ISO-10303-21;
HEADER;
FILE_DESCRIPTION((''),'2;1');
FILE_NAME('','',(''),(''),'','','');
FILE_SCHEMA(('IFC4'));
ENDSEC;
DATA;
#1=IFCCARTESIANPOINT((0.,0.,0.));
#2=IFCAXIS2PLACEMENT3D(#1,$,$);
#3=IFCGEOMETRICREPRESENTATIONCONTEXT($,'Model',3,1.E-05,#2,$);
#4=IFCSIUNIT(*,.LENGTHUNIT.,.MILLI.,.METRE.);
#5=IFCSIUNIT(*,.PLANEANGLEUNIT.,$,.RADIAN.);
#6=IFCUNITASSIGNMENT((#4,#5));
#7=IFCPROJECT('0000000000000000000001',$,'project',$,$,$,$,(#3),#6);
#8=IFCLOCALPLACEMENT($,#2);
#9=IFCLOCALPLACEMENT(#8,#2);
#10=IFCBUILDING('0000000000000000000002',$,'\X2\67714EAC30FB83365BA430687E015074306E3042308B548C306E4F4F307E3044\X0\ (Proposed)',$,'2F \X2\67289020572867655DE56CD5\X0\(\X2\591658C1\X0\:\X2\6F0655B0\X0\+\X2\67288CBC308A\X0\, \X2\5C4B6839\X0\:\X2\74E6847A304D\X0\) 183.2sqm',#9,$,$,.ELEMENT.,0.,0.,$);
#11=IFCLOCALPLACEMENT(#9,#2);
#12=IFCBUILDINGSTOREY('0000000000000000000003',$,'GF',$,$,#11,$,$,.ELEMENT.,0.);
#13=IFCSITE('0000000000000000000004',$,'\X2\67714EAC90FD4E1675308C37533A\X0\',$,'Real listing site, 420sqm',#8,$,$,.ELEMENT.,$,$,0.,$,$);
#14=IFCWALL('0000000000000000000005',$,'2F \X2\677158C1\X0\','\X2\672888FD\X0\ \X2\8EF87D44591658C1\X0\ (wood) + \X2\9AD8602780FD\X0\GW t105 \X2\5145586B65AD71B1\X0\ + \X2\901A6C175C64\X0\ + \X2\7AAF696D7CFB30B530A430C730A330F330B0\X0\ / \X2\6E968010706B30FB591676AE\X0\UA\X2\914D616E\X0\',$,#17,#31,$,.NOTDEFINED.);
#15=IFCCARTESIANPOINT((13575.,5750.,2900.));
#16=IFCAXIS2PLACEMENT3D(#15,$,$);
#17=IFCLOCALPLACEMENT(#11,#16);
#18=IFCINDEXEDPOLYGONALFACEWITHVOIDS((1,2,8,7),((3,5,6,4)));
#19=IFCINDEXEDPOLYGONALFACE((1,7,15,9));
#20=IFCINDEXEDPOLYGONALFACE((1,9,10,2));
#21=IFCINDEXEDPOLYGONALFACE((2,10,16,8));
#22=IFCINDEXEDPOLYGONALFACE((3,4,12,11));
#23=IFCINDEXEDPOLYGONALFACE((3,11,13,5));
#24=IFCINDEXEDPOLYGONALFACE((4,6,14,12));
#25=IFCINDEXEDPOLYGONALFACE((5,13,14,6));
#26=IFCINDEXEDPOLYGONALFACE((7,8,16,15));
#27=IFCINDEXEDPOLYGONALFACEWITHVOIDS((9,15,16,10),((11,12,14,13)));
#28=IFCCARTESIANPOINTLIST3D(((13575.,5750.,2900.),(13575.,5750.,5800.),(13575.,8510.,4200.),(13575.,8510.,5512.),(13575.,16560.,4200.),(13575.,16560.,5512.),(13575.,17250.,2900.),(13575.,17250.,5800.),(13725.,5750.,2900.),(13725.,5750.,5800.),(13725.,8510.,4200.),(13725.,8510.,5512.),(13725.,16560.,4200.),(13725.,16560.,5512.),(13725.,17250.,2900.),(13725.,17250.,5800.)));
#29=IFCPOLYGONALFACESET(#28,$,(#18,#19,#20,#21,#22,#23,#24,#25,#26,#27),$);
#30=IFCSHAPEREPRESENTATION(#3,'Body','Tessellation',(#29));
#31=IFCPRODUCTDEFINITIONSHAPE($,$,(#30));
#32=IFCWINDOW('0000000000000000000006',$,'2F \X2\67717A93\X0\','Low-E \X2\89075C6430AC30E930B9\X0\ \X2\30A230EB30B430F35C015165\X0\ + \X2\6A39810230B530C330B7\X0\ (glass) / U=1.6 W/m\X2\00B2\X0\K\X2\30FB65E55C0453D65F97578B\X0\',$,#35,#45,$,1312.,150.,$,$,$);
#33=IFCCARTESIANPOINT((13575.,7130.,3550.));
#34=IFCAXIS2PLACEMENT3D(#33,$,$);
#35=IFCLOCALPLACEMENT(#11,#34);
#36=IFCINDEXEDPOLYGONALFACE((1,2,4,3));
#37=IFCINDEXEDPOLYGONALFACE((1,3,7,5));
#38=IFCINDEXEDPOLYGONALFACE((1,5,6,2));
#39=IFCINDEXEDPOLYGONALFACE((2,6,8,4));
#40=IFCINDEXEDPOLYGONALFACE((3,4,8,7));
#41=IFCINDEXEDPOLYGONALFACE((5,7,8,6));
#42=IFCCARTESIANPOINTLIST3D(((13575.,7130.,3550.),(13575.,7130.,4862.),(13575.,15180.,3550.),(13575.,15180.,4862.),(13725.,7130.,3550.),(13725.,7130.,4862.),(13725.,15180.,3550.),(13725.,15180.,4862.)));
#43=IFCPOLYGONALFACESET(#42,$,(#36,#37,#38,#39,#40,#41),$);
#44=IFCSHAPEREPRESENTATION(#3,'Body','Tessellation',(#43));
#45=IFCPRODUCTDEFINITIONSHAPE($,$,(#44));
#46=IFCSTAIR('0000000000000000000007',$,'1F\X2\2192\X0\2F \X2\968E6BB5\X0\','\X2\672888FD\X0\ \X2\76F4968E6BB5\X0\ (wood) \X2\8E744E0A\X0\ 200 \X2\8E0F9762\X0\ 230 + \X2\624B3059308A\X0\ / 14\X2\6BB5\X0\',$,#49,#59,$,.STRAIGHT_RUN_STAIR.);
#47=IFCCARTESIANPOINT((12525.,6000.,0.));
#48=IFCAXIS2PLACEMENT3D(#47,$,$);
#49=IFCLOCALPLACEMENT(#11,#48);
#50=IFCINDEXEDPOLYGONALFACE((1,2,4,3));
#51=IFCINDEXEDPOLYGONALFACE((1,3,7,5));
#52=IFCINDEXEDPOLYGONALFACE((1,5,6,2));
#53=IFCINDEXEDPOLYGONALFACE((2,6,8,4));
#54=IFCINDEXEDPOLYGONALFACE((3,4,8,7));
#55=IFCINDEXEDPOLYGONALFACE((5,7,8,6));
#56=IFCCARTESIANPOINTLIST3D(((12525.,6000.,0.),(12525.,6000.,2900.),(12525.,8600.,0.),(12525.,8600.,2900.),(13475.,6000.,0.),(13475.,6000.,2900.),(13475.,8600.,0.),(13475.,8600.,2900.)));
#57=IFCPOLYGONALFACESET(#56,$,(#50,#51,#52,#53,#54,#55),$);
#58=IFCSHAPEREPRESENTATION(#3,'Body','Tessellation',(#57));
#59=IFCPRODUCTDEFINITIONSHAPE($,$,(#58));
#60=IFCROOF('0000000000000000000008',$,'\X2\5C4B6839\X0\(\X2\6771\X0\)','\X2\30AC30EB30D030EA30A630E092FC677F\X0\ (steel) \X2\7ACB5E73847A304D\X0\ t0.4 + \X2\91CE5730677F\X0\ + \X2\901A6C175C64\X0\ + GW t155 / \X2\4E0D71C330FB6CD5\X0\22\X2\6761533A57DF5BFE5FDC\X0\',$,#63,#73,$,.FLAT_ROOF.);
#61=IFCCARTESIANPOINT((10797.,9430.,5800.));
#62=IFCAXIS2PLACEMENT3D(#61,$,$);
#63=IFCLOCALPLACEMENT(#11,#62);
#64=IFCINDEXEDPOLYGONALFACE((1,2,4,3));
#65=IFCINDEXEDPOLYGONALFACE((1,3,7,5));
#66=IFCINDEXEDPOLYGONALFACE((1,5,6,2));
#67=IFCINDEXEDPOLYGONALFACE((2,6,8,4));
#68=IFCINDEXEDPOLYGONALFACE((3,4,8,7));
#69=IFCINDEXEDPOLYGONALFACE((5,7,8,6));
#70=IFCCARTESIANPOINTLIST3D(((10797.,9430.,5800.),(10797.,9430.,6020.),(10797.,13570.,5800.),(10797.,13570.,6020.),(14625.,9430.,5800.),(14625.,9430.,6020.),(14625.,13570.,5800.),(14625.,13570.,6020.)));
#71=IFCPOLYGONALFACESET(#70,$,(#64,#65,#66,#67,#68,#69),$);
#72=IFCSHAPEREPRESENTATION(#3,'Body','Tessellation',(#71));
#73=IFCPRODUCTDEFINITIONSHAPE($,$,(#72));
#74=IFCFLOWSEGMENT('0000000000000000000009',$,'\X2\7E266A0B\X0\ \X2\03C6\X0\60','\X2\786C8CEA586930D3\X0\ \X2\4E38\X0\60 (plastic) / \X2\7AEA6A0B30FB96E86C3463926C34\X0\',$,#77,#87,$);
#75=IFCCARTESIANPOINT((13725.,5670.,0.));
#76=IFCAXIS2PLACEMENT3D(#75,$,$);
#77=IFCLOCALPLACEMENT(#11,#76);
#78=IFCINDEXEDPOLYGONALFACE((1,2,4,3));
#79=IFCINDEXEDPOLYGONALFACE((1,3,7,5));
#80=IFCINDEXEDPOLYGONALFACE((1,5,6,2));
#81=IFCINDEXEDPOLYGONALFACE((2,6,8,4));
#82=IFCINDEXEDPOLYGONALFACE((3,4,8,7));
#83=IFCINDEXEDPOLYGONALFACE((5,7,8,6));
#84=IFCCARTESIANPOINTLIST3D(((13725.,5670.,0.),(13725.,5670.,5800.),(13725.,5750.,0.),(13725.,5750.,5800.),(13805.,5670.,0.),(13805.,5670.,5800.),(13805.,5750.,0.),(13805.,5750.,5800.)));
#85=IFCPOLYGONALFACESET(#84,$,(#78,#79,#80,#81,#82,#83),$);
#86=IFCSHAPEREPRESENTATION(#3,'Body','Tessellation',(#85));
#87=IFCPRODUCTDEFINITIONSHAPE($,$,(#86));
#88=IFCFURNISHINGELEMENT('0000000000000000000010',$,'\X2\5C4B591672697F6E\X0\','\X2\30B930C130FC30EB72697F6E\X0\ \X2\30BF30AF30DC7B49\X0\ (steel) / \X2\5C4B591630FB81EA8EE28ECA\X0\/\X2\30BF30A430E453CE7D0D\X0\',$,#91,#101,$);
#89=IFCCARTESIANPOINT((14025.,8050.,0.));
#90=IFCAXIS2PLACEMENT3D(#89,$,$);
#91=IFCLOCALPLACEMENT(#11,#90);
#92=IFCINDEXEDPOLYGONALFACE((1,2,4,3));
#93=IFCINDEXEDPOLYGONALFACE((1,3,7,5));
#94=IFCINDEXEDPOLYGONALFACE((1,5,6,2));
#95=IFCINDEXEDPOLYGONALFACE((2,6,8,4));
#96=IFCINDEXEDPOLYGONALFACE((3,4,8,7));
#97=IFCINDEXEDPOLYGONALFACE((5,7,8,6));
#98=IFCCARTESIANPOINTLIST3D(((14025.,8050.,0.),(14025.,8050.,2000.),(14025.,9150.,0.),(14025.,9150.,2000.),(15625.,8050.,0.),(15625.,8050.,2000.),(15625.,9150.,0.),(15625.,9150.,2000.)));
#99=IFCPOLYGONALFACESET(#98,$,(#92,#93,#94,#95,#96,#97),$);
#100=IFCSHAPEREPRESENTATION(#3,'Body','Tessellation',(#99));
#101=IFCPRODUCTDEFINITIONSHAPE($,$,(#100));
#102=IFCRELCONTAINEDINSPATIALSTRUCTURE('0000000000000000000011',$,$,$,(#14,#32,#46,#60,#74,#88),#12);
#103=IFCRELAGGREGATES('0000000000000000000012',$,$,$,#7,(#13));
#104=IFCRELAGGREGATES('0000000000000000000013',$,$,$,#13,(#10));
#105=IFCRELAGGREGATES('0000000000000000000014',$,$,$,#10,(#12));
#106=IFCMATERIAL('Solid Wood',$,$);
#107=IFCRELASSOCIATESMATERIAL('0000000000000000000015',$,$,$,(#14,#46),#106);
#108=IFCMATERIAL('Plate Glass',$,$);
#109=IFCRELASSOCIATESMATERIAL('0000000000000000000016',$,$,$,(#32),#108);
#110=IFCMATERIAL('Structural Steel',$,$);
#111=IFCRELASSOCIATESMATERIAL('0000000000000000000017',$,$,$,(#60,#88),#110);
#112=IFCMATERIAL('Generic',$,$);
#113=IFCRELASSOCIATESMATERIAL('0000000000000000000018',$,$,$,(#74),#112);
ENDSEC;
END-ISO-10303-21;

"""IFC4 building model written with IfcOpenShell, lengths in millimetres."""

from ifc_helpers import new_model, si_unit, frame, frame_2d, origin, place, context, project, spatial, rectangle, extrude, material, element, fill, save


model = new_model("IFC4")

# Units and contexts
model_context = context("Model", 3, precision=1e-05, world=origin())
ifc_project = project(units=[si_unit("LENGTHUNIT", "METRE", prefix="MILLI"), si_unit("PLANEANGLEUNIT", "RADIAN")], contexts=[model_context])

# Site, building, storey
site_placement = place(None, origin())
site = spatial("IfcSite", under=ifc_project, at=site_placement, Name="東京都世田谷区", ObjectType="Real listing site, 420sqm", CompositionType="ELEMENT", RefElevation=0.0)
building_placement = place(site_placement, origin())
building = spatial("IfcBuilding", under=site, at=building_placement, Name="東京・茶室と縁側のある和の住まい (Proposed)", ObjectType="2F 木造在来工法(外壁:漆喰+木貼り, 屋根:瓦葺き) 183.2sqm", CompositionType="ELEMENT", ElevationOfRefHeight=0.0, ElevationOfTerrain=0.0)
storey_placement = place(building_placement, origin())
storey = spatial("IfcBuildingStorey", under=building, at=storey_placement, Name="GF", CompositionType="ELEMENT", Elevation=0.0)

# Shared definitions
ifc_material_1 = material(Name="Solid Wood")

# Wall, opening, window
ifc_material_2 = material(Name="Plate Glass")
wall_1_placement = place(storey_placement, frame((13575.0, 5750.0, 2900.0)))
wall_1 = element("IfcWall", 1, at=wall_1_placement, inside=storey, material=ifc_material_1, Name="2F 東壁", Description="木製 軸組外壁 (wood) + 高性能GW t105 充填断熱 + 通気層 + 窯業系サイディング / 準耐火・外皮UA配慮", PredefinedType="NOTDEFINED", context=model_context, shape_type="SweptSolid", body=[
    extrude(rectangle(XDim=150.0, YDim=11500.0, at=frame_2d((75.0, 5750.0))), frame((13575.0, 5750.0, 2900.0)), (0.0, 0.0, 1.0), 2900.0),
])
opening_1_placement = place(storey_placement, frame((13575.0, 7130.0, 3550.0)))
opening_1 = element("IfcOpeningElement", 2, at=opening_1_placement, cuts=wall_1, PredefinedType="NOTDEFINED", context=model_context, shape_type="SweptSolid", body=[
    extrude(rectangle(XDim=150.0, YDim=8050.0, at=frame_2d((75.0, 4025.0))), frame((13575.0, 7130.0, 3550.0)), (0.0, 0.0, 1.0), 1312.0),
])
window_1_placement = place(storey_placement, frame((13575.0, 7130.0, 3550.0)))
window_1 = element("IfcWindow", 3, at=window_1_placement, inside=storey, material=ifc_material_2, Name="2F 東窓", Description="Low-E 複層ガラス アルゴン封入 + 樹脂サッシ (glass) / U=1.6 W/m²K・日射取得型", OverallHeight=1312.0, OverallWidth=150.0, context=model_context, shape_type="SweptSolid", body=[
    extrude(rectangle(XDim=150.0, YDim=8050.0, at=frame_2d((75.0, 4025.0))), frame((13575.0, 7130.0, 3550.0)), (0.0, 0.0, 1.0), 1312.0),
])
fill(opening_1, window_1)

# Stair
stair_placement = place(storey_placement, frame((12525.0, 6000.0, 0.0)))
element("IfcStair", 4, at=stair_placement, inside=storey, material=ifc_material_1, Name="1F→2F 階段", Description="木製 直階段 (wood) 蹴上 200 踏面 230 + 手すり / 14段", PredefinedType="STRAIGHT_RUN_STAIR", context=model_context, shape_type="SweptSolid", body=[
    extrude(rectangle(XDim=950.0, YDim=2600.0, at=frame_2d((475.0, 1300.0))), frame((12525.0, 6000.0, 0.0)), (0.0, 0.0, 1.0), 2900.0),
])

# Roof
ifc_material_3 = material(Name="Structural Steel")
roof_placement = place(storey_placement, frame((10797.0, 9430.0, 5800.0)))
element("IfcRoof", 5, at=roof_placement, inside=storey, material=ifc_material_3, Name="屋根(東)", Description="ガルバリウム鋼板 (steel) 立平葺き t0.4 + 野地板 + 通気層 + GW t155 / 不燃・法22条区域対応", PredefinedType="FLAT_ROOF", context=model_context, shape_type="SweptSolid", body=[
    extrude(rectangle(XDim=3828.0, YDim=4140.0, at=frame_2d((1914.0, 2070.0))), frame((10797.0, 9430.0, 5800.0)), (0.0, 0.0, 1.0), 220.0),
])

# Flow segment
ifc_material_4 = material(Name="Generic")
flow_segment_placement = place(storey_placement, frame((13725.0, 5670.0, 0.0)))
element("IfcFlowSegment", 6, at=flow_segment_placement, inside=storey, material=ifc_material_4, Name="縦樋 φ60", Description="硬質塩ビ 丸60 (plastic) / 竪樋・雨水排水", context=model_context, shape_type="SweptSolid", body=[
    extrude(rectangle(XDim=80.0, YDim=80.0, at=frame_2d((40.0, 40.0))), frame((13725.0, 5670.0, 0.0)), (0.0, 0.0, 1.0), 5800.0),
])

# Furnishing element
furnishing_placement = place(storey_placement, frame((14025.0, 8050.0, 0.0)))
element("IfcFurnishingElement", 7, at=furnishing_placement, inside=storey, material=ifc_material_3, Name="屋外物置", Description="スチール物置 タクボ等 (steel) / 屋外・自転車/タイヤ収納", context=model_context, shape_type="SweptSolid", body=[
    extrude(rectangle(XDim=1600.0, YDim=1100.0, at=frame_2d((800.0, 550.0))), frame((14025.0, 8050.0, 0.0)), (0.0, 0.0, 1.0), 2000.0),
])

save(model, "model.ifc")
